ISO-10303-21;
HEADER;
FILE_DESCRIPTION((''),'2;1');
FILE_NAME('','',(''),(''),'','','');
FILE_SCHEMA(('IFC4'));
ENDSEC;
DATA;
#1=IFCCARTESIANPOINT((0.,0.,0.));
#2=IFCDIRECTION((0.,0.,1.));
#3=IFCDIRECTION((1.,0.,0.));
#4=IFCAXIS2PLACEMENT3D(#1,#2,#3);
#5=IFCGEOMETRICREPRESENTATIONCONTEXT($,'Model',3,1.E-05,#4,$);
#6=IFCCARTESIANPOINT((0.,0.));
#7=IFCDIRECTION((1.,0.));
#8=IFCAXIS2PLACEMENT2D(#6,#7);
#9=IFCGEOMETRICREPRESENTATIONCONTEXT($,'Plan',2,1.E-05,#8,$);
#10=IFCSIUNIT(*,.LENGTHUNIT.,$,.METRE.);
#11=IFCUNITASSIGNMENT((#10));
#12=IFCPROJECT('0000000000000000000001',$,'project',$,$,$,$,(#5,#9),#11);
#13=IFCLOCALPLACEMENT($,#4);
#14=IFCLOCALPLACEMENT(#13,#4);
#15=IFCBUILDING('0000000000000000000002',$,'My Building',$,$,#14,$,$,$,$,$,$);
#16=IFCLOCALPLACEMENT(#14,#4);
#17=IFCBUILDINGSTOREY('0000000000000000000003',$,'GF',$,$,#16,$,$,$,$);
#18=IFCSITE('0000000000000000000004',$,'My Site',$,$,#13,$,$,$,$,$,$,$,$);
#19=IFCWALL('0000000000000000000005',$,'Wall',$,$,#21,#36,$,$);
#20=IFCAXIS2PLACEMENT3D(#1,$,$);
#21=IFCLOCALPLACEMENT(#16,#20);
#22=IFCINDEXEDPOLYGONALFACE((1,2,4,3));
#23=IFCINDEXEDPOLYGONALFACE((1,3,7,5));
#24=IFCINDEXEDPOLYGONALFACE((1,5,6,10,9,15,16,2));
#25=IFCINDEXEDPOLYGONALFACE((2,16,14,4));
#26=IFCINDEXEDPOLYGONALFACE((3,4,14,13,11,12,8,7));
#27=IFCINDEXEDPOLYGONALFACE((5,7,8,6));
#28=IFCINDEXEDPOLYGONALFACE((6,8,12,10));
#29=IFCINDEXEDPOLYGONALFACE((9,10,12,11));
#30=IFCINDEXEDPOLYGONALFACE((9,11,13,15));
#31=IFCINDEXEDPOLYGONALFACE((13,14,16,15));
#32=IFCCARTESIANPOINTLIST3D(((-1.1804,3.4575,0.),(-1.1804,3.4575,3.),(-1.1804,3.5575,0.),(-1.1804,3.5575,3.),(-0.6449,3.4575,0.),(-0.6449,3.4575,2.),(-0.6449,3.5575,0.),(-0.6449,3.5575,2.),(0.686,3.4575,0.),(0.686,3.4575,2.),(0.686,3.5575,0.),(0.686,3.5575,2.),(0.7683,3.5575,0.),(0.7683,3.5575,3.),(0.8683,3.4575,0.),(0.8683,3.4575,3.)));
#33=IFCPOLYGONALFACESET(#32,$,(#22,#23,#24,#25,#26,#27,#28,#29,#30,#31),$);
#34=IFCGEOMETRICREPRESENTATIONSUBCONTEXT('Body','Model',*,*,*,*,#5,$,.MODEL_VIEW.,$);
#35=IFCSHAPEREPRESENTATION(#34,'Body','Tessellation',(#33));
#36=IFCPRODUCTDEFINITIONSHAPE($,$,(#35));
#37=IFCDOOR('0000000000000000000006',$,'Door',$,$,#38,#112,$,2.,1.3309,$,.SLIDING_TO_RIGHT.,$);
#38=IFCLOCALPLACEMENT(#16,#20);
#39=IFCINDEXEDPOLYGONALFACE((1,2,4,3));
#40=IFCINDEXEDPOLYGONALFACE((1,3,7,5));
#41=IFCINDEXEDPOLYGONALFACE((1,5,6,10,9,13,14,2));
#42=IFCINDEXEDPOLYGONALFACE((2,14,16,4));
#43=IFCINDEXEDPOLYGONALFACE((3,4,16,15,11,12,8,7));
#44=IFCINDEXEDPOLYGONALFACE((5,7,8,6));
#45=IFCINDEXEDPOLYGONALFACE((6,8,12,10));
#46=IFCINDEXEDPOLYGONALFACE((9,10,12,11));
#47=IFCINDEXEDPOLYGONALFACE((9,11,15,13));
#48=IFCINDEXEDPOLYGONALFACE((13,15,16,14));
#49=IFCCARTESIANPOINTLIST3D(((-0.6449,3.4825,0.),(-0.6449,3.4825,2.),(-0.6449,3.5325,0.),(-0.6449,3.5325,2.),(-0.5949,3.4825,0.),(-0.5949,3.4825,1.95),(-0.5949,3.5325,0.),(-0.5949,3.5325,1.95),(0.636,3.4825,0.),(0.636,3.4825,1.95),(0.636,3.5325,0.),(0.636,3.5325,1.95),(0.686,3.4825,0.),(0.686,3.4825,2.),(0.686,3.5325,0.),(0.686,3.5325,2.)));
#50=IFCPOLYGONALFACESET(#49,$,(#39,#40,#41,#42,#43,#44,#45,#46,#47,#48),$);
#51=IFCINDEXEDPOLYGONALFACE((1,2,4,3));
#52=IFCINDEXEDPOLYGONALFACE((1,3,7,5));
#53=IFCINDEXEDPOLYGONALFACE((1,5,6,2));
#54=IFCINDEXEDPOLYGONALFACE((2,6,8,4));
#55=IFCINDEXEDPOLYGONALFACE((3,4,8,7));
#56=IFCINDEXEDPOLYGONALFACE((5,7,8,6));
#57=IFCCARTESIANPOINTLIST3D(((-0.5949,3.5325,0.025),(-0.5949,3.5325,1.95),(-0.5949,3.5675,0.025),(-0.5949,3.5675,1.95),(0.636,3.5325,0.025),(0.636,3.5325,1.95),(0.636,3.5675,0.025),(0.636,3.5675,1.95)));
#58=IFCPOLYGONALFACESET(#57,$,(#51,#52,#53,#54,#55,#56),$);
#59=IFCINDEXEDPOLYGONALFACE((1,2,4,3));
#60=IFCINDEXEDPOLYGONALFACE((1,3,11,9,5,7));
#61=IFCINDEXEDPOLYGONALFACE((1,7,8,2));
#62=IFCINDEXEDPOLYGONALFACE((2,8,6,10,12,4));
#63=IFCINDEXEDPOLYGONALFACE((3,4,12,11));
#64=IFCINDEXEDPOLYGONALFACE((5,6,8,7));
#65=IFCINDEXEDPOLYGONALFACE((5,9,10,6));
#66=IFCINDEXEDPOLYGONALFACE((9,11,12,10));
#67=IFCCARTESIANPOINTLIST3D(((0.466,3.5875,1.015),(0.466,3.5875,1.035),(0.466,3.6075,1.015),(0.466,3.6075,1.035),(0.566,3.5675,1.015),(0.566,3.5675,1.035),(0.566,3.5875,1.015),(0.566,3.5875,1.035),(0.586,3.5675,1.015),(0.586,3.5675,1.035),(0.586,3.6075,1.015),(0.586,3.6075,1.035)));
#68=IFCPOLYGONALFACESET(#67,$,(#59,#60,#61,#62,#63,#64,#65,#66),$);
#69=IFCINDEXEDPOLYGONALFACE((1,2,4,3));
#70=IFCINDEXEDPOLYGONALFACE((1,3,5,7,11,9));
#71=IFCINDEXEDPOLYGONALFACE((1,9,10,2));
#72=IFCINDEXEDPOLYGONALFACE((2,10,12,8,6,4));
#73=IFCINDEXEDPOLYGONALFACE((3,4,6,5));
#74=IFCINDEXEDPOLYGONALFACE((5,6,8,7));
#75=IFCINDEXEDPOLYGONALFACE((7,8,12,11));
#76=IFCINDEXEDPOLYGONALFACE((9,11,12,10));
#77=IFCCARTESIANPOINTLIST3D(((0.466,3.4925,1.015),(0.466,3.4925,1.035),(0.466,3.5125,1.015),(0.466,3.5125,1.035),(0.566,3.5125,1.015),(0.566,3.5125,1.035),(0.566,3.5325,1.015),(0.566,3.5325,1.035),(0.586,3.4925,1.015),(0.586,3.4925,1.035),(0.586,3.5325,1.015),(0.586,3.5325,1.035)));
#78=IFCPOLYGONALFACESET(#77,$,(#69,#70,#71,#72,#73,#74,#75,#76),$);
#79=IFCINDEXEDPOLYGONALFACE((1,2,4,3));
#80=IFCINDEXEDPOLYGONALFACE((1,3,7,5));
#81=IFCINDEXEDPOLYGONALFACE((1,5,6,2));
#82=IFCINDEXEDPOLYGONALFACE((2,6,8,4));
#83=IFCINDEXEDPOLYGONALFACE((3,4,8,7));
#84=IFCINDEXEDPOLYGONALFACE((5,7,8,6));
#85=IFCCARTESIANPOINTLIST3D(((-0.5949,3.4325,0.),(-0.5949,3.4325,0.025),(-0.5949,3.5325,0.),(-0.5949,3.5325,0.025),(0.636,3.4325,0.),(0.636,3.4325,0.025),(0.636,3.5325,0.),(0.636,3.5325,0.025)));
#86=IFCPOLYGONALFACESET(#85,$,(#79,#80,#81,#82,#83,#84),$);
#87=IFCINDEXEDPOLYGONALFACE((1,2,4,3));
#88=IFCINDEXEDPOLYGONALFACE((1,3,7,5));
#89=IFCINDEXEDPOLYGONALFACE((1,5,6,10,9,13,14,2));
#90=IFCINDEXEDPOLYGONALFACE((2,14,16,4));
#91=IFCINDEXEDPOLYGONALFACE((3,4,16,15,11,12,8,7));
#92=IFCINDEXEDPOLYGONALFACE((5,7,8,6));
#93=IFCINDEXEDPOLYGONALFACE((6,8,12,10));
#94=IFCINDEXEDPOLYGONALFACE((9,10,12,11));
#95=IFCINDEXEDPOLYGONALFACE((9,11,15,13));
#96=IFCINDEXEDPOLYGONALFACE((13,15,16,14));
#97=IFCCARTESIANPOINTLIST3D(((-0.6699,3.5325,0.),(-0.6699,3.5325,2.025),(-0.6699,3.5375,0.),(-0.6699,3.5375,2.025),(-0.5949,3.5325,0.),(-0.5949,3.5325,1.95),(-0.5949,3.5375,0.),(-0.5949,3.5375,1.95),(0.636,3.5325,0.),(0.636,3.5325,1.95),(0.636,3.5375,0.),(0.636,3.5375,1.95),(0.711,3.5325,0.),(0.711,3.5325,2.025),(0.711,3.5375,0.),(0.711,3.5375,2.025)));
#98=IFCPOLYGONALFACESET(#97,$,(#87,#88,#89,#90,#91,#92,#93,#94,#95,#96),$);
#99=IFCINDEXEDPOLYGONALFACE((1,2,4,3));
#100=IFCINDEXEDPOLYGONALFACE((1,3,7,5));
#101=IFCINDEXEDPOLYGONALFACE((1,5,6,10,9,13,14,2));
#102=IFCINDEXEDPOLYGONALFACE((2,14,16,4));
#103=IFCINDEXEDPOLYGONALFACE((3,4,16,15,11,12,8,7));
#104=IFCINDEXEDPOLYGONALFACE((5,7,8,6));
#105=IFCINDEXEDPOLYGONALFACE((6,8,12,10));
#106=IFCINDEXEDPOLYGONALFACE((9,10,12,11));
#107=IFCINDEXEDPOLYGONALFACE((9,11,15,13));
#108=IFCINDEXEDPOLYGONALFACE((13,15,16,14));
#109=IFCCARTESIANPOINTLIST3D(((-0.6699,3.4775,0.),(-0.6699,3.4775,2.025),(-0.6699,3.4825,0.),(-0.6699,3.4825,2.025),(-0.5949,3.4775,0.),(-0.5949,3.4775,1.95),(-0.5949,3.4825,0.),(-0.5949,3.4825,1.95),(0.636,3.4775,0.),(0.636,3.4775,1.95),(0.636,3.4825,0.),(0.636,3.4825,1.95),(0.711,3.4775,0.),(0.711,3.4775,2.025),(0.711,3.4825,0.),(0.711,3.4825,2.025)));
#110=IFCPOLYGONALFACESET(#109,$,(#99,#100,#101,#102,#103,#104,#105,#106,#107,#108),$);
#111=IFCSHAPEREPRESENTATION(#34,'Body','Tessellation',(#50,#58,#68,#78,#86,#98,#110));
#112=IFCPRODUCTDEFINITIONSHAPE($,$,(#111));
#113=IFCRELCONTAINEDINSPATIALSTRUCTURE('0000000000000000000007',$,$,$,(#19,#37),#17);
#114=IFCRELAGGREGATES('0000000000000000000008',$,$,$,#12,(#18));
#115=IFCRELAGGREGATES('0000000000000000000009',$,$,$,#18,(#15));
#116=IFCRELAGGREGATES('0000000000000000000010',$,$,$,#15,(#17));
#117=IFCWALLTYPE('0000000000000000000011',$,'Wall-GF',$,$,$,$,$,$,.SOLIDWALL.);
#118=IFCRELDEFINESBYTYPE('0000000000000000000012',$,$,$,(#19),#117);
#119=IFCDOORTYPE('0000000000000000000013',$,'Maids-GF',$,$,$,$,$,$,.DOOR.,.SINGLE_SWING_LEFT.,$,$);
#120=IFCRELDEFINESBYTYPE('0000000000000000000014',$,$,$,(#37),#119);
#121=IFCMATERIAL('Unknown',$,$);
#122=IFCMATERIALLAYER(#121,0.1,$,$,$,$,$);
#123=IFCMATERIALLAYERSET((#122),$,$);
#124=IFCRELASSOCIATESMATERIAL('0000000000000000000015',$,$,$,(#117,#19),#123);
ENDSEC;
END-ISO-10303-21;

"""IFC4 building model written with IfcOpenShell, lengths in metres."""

from ifc_helpers import new_model, entity, si_unit, frame, origin_with_axes, origin_2d_with_axis, place, context, subcontext, project, spatial, line, indexed_curve, outline, extrude, shape, source, transform, mapped, material, layer, layer_set, layer_usage, type_object, type_shapes, element, fill, save


model = new_model("IFC4")

# Units and contexts
model_context = context("Model", 3, precision=1e-05, world=origin_with_axes())
plan_context = context("Plan", 2, precision=1e-05, world=origin_2d_with_axis())
body_context_1 = subcontext(model_context, "Body", "Model", "MODEL_VIEW")
body_context_2 = subcontext(plan_context, "Body", "Plan", "PLAN_VIEW")
ifc_project = project(units=[si_unit("LENGTHUNIT", "METRE")], contexts=[model_context, plan_context])

# Site, building, storey
site_placement = place(None, origin_with_axes())
site = spatial("IfcSite", under=ifc_project, at=site_placement, Name="My Site")
building_placement = place(site_placement, origin_with_axes())
building = spatial("IfcBuilding", under=site, at=building_placement, Name="My Building")
storey_placement = place(building_placement, origin_with_axes())
storey = spatial("IfcBuildingStorey", under=building, at=storey_placement, Name="GF")

# Shared definitions
ifc_material = material(Name="Unknown")

# Shared definitions
ifc_layer_1 = layer(ifc_material, 0.1)
ifc_layer_set_1 = layer_set([ifc_layer_1])
wall_type = type_object("IfcWallType", Name="Wall-GF", PredefinedType="SOLIDWALL", material=ifc_layer_set_1)

# Wall, opening, door
ifc_layer_usage_1 = layer_usage(ifc_layer_set_1, "AXIS2", "POSITIVE", 0.0)
wall_1_placement = place(storey_placement, frame((0.7683, 3.5575, 0.0), z_axis=(0.0, 0.0, 1.0), x_axis=(-1.0, 0.0, 0.0)))
wall_1 = element("IfcWall", 1, at=wall_1_placement, inside=storey, type_object=wall_type, material=ifc_layer_usage_1, Name="Wall", context=body_context_1, shape_type="SweptSolid", body=[
    extrude(outline(indexed_curve([(0.0, 0.0), (-0.1, 0.1), (1.9488, 0.1), (1.9488, 0.0)], segments=[line(1, 2, 3, 4, 1)])), origin_with_axes(), (0.0, 0.0, 1.0), 3.0),
])
shared_shape_1 = source(origin_with_axes(), body_context_1, "Body", "SweptSolid", [
    extrude(outline(indexed_curve([(0.0, 0.0), (1.3309, 0.0), (1.3309, 2.0), (0.0, 2.0)], segments=[line(1, 2, 3, 4, 1)])), frame((0.0, -0.6, 0.0), z_axis=(0.0, -1.0, 0.0), x_axis=(1.0, 0.0, 0.0)), (0.0, 0.0, -1.0), 1.2),
])
opening_1_placement = place(wall_1_placement, frame((0.0824, 0.025, 0.0), z_axis=(0.0, 0.0, 1.0), x_axis=(1.0, -0.000001, 0.0)))
opening_1 = element("IfcOpeningElement", 2, at=opening_1_placement, cuts=wall_1, PredefinedType="OPENING", context=body_context_1, shape_type="MappedRepresentation", body=[
    mapped(shared_shape_1, transform((0.0, 0.0, 0.0), x_axis=(1.0, 0.0, 0.0), y_axis=(0.0, 1.0, 0.0), z_axis=(0.0, 0.0, 1.0), scale=1.0)),
])
door_type_1 = type_object("IfcDoorType", Name="Maids-GF", OperationType="SINGLE_SWING_LEFT", PredefinedType="DOOR")
shared_shape_2 = source(origin_with_axes(), body_context_1, "Body", "SweptSolid", [
    extrude(outline(indexed_curve([(0.0, 0.0), (0.0, 2.0), (1.3309, 2.0), (1.3309, 0.0), (1.2809, 0.0), (1.2809, 1.95), (0.05, 1.95), (0.05, 0.0)], segments=[line(1, 2, 3, 4, 5, 6, 7, 8, 1)])), frame((0.0, 0.0, 0.0), z_axis=(0.0, -1.0, 0.0), x_axis=(1.0, 0.0, 0.0)), (0.0, 0.0, -1.0), 0.05),
    extrude(outline(indexed_curve([(0.0, 0.0), (1.2309, 0.0), (1.2309, 0.035), (0.0, 0.035)], segments=[line(1, 2, 3, 4, 1)])), frame((0.05, -0.035, 0.025), z_axis=(0.0, 0.0, 1.0), x_axis=(1.0, 0.0, 0.0)), (0.0, 0.0, 1.0), 1.925),
    extrude(outline(indexed_curve([(0.0, 0.0), (0.0, -0.04), (0.12, -0.04), (0.12, -0.02), (0.02, -0.02), (0.02, 0.0)], segments=[line(1, 2, 3, 4, 5, 6, 1)])), frame((0.1, -0.035, 1.015), z_axis=(0.0, 0.0, 1.0), x_axis=(1.0, 0.0, 0.0)), (0.0, 0.0, 1.0), 0.02),
    extrude(outline(indexed_curve([(0.0, 0.0), (0.0, 0.04), (0.12, 0.04), (0.12, 0.02), (0.02, 0.02), (0.02, 0.0)], segments=[line(1, 2, 3, 4, 5, 6, 1)])), frame((0.1, 0.0, 1.015), z_axis=(0.0, 0.0, 1.0), x_axis=(1.0, 0.0, 0.0)), (0.0, 0.0, 1.0), 0.02),
    extrude(outline(indexed_curve([(0.0, 0.0), (1.2309, 0.0), (1.2309, 0.1), (0.0, 0.1)], segments=[line(1, 2, 3, 4, 1)])), frame((0.05, 0.0, 0.0), z_axis=(0.0, 0.0, 1.0), x_axis=(1.0, 0.0, 0.0)), (0.0, 0.0, 1.0), 0.025),
    extrude(outline(indexed_curve([(0.0, 0.0), (0.0, 2.025), (1.3809, 2.025), (1.3809, 0.0), (1.3059, 0.0), (1.3059, 1.95), (0.075, 1.95), (0.075, 0.0)], segments=[line(1, 2, 3, 4, 5, 6, 7, 8, 1)])), frame((-0.025, -0.005, 0.0), z_axis=(0.0, -1.0, 0.0), x_axis=(1.0, 0.0, 0.0)), (0.0, 0.0, -1.0), 0.005),
    extrude(outline(indexed_curve([(0.0, 0.0), (0.0, 2.025), (1.3809, 2.025), (1.3809, 0.0), (1.3059, 0.0), (1.3059, 1.95), (0.075, 1.95), (0.075, 0.0)], segments=[line(1, 2, 3, 4, 5, 6, 7, 8, 1)])), frame((-0.025, 0.05, 0.0), z_axis=(0.0, -1.0, 0.0), x_axis=(1.0, 0.0, 0.0)), (0.0, 0.0, -1.0), 0.005),
])
shared_shape_3 = source(origin_with_axes(), body_context_2, "Body", "Curve2D", [
    entity("IfcIndexedPolyCurve", entity("IfcCartesianPointList2D", [[0.0, 0.0], [0.05, 0.0], [0.05, 0.05], [0.0, 0.05]]), [entity("IfcLineIndex", [1, 2, 3, 4, 1])]),
    entity("IfcIndexedPolyCurve", entity("IfcCartesianPointList2D", [[1.3309, 0.0], [1.2809, 0.0], [1.2809, 0.05], [1.3309, 0.05]]), [entity("IfcLineIndex", [1, 2, 3, 4, 1])]),
    entity("IfcIndexedPolyCurve", entity("IfcCartesianPointList2D", [[1.8964, -0.035], [0.6655, -0.035], [0.6655, 0.0], [1.8964, 0.0]]), [entity("IfcLineIndex", [1, 2, 3, 4, 1])]),
])
type_shapes(door_type_1, [shared_shape_2, shared_shape_3])
door_1_placement = place(opening_1_placement, frame((0.0, 0.0, 0.0), z_axis=(0.0, 0.0, 1.0), x_axis=(1.0, 0.0, 0.0)))
door_1 = element("IfcDoor", 3, at=door_1_placement, inside=storey, type_object=door_type_1, Name="Door", OperationType="SLIDING_TO_RIGHT", OverallHeight=2.0, OverallWidth=1.3309, shapes=[
    shape(body_context_1, "Body", "MappedRepresentation", [mapped(shared_shape_2, transform((0.0, 0.0, 0.0), x_axis=(1.0, 0.0, 0.0), y_axis=(0.0, 1.0, 0.0), z_axis=(0.0, 0.0, 1.0), scale=1.0))]),
    shape(body_context_2, "Body", "MappedRepresentation", [mapped(shared_shape_3, transform((0.0, 0.0, 0.0), x_axis=(1.0, 0.0, 0.0), y_axis=(0.0, 1.0, 0.0), z_axis=(0.0, 0.0, 1.0), scale=1.0))]),
])
fill(opening_1, door_1)

save(model, "model.ifc")
